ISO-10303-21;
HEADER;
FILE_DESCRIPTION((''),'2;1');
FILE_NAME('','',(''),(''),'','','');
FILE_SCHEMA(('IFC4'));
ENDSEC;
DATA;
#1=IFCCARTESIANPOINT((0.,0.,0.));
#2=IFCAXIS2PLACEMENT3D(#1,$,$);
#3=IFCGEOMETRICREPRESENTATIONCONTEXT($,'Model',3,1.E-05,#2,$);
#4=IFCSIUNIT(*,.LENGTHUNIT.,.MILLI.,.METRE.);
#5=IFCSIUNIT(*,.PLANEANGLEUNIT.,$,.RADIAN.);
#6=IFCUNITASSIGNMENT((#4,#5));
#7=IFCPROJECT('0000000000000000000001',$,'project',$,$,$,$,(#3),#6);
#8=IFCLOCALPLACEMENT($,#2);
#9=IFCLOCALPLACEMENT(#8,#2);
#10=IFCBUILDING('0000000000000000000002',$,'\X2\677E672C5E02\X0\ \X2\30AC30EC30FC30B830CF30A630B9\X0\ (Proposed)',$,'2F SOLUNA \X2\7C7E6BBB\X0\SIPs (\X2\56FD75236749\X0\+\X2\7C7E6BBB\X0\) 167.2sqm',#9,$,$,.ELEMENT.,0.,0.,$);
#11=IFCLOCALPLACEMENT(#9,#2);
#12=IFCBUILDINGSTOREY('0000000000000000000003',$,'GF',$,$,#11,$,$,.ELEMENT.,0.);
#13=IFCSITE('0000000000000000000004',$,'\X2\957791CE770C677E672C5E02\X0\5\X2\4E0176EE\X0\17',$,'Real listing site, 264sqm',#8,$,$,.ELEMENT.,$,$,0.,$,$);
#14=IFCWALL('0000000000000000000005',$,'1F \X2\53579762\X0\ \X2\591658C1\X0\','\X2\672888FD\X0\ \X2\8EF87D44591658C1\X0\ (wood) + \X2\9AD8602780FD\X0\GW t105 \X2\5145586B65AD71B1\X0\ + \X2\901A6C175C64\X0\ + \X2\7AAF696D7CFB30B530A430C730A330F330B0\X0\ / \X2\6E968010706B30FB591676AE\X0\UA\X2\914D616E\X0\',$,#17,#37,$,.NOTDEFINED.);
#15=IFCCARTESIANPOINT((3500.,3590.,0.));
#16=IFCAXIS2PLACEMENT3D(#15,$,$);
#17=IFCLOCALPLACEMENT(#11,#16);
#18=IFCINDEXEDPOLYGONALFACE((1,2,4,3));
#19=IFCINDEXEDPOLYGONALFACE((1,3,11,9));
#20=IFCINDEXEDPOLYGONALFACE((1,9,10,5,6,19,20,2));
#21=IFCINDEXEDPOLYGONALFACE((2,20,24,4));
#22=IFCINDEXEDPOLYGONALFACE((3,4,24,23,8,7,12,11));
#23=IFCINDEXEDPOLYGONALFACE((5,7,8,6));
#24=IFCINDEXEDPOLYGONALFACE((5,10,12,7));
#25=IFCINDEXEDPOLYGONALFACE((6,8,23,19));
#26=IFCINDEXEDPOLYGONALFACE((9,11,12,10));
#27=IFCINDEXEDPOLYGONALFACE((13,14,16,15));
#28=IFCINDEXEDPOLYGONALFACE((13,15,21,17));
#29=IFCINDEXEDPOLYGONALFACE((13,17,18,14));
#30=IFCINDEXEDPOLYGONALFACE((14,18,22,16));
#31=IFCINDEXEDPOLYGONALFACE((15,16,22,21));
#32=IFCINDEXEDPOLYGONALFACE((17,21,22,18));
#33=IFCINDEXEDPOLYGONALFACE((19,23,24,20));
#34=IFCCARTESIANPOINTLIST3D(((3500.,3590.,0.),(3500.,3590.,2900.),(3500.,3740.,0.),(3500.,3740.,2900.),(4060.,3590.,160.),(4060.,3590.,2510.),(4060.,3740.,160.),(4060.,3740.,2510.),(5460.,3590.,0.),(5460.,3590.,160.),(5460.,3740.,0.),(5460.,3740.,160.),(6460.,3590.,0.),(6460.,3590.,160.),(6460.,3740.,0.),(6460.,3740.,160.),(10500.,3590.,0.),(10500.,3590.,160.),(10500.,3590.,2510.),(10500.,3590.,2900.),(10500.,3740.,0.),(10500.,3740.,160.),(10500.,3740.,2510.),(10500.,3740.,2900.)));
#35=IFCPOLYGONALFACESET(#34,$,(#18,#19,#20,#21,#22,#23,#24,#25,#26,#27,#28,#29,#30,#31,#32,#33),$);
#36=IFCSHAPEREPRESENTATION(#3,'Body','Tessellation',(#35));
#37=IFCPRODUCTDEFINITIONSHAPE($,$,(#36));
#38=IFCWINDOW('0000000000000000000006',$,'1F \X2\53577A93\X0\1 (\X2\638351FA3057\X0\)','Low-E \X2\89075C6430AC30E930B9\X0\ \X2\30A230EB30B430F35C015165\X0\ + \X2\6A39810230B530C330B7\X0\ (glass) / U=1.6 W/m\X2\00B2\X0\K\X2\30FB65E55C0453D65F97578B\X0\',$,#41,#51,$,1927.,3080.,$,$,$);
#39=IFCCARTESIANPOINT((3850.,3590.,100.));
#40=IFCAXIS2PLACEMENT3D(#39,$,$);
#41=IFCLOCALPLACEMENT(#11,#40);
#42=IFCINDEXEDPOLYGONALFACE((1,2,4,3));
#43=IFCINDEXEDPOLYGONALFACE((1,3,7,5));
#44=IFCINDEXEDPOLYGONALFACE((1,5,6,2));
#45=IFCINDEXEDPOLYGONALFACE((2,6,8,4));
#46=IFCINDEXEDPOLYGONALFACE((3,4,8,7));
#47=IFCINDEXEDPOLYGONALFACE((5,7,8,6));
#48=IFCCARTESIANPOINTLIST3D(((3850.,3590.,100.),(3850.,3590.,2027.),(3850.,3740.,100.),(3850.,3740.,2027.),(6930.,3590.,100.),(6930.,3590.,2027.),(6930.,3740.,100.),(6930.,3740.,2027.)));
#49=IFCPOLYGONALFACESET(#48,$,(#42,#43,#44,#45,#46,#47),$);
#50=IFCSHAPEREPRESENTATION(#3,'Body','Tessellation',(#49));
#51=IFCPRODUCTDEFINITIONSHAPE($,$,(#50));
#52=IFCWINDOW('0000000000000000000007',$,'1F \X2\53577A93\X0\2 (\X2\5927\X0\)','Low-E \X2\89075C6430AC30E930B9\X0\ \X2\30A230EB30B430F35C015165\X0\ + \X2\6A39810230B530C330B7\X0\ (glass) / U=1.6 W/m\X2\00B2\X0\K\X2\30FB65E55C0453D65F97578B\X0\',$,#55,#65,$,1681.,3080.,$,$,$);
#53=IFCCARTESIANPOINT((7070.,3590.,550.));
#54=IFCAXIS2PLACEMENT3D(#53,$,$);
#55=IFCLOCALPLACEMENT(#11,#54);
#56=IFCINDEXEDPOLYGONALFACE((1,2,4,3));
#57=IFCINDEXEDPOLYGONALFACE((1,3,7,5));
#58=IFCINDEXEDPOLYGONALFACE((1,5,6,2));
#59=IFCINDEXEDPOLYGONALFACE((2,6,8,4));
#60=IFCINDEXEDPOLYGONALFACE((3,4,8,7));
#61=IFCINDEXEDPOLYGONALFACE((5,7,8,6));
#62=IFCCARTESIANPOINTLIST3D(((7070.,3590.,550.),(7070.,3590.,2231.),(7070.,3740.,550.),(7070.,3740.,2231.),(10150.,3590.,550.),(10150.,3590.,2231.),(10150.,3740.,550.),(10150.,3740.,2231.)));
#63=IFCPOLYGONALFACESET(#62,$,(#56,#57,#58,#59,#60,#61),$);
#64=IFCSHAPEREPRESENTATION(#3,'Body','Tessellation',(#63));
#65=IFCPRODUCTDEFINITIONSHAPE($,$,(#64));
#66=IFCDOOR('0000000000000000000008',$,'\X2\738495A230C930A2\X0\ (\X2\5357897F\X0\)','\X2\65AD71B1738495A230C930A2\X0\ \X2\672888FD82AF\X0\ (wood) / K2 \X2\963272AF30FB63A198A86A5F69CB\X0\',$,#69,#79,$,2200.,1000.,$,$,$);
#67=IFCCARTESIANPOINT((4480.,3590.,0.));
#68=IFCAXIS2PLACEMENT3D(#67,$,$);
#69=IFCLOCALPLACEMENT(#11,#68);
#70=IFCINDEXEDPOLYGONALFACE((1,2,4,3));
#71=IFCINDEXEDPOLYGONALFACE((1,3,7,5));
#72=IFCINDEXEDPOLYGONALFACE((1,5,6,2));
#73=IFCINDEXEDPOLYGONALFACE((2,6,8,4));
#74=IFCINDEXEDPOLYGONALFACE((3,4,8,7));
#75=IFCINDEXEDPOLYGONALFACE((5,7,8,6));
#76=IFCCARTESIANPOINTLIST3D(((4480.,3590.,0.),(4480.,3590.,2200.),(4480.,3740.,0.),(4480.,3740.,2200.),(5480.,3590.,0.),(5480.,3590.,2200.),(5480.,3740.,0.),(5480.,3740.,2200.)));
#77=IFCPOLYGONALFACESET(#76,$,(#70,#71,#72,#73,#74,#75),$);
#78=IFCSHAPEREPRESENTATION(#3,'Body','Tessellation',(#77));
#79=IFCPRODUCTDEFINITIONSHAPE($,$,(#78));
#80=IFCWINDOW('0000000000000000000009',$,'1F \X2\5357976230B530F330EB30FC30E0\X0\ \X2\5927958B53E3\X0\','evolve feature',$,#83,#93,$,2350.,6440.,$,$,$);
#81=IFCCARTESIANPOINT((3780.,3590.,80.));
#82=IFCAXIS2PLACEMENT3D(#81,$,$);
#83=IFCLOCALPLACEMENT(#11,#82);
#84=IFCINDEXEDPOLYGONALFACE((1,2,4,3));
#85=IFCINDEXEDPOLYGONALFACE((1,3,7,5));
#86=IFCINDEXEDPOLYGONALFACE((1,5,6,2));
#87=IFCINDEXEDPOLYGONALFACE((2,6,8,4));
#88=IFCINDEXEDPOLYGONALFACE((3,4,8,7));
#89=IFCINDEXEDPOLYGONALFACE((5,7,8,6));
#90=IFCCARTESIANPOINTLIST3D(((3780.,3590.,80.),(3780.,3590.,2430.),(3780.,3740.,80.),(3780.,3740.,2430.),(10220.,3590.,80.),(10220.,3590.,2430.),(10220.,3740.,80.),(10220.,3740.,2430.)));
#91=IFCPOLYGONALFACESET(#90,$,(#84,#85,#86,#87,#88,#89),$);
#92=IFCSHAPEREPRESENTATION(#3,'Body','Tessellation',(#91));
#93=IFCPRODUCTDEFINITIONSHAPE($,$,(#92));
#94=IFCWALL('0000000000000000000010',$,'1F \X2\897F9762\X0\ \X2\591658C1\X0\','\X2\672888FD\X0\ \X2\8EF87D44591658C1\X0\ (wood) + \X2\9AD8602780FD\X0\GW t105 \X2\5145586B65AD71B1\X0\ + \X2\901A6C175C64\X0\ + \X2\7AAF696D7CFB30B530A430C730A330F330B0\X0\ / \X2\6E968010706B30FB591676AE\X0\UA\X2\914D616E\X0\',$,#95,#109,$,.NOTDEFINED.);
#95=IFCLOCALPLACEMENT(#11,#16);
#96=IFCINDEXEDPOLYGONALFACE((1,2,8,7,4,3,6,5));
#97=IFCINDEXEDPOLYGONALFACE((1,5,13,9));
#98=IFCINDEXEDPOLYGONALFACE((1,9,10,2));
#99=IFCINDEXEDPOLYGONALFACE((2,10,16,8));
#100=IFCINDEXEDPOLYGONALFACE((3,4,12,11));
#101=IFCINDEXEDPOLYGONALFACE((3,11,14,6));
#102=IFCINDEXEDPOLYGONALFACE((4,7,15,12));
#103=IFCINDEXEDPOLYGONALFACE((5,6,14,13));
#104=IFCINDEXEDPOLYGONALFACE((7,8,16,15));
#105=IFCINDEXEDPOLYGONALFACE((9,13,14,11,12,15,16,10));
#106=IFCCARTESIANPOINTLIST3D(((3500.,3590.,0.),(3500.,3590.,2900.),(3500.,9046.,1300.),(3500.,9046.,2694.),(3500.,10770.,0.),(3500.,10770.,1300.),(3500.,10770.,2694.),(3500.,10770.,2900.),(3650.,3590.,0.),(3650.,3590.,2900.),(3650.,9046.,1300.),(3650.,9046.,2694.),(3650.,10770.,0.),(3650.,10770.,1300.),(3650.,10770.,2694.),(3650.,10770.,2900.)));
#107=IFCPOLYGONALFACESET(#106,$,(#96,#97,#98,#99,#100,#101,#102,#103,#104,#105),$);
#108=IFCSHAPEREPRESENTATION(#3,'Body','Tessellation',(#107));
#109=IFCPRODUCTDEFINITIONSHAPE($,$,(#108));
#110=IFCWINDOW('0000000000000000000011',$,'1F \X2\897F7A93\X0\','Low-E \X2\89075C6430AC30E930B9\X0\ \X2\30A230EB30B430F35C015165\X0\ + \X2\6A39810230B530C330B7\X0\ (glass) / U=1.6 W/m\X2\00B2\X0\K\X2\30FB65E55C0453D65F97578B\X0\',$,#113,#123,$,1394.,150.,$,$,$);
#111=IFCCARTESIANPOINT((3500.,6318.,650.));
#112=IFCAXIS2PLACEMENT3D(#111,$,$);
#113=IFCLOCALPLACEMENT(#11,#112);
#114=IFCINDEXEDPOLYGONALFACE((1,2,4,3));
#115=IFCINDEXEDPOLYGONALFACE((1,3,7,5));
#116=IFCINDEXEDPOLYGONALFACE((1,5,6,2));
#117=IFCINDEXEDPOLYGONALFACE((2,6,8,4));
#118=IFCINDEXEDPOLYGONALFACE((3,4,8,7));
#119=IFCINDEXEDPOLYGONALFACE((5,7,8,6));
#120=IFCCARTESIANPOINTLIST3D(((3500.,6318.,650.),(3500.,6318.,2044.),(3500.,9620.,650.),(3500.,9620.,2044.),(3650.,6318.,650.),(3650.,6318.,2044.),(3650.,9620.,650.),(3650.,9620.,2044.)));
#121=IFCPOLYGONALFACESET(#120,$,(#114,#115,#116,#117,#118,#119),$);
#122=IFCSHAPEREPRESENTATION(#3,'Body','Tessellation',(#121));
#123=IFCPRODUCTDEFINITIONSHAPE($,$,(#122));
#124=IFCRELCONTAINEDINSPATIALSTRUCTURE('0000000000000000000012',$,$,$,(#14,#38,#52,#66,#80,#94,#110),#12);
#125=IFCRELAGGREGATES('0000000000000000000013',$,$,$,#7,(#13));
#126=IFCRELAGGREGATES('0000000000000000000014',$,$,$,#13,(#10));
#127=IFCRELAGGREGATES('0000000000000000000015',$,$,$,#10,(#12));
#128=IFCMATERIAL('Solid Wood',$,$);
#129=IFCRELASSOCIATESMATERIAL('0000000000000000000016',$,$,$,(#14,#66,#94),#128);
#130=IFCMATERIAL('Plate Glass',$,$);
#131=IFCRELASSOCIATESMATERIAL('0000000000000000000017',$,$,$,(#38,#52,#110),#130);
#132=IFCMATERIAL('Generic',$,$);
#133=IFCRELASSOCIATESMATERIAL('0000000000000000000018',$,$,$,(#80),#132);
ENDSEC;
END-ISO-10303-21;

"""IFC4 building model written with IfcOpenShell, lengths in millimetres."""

from ifc_helpers import new_model, si_unit, frame, frame_2d, origin, place, context, project, spatial, rectangle, extrude, material, element, fill, save


model = new_model("IFC4")

# Units and contexts
model_context = context("Model", 3, precision=1e-05, world=origin())
ifc_project = project(units=[si_unit("LENGTHUNIT", "METRE", prefix="MILLI"), si_unit("PLANEANGLEUNIT", "RADIAN")], contexts=[model_context])

# Site, building, storey
site_placement = place(None, origin())
site = spatial("IfcSite", under=ifc_project, at=site_placement, Name="長野県松本市5丁目17", ObjectType="Real listing site, 264sqm", CompositionType="ELEMENT", RefElevation=0.0)
building_placement = place(site_placement, origin())
building = spatial("IfcBuilding", under=site, at=building_placement, Name="松本市 ガレージハウス (Proposed)", ObjectType="2F SOLUNA 籾殻SIPs (国産杉+籾殻) 167.2sqm", CompositionType="ELEMENT", ElevationOfRefHeight=0.0, ElevationOfTerrain=0.0)
storey_placement = place(building_placement, origin())
storey = spatial("IfcBuildingStorey", under=building, at=storey_placement, Name="GF", CompositionType="ELEMENT", Elevation=0.0)

# Shared definitions
ifc_material_1 = material(Name="Solid Wood")
ifc_material_2 = material(Name="Generic")

# Wall, openings, windows, door
wall_1_placement = place(storey_placement, frame((3500.0, 3590.0, 0.0)))
wall_1 = element("IfcWall", 1, at=wall_1_placement, inside=storey, material=ifc_material_1, Name="1F 南面 外壁", Description="木製 軸組外壁 (wood) + 高性能GW t105 充填断熱 + 通気層 + 窯業系サイディング / 準耐火・外皮UA配慮", PredefinedType="NOTDEFINED", context=model_context, shape_type="SweptSolid", body=[
    extrude(rectangle(XDim=7000.0, YDim=150.0, at=frame_2d((3500.0, 75.0))), frame((3500.0, 3590.0, 0.0)), (0.0, 0.0, 1.0), 2900.0),
])
opening_1_placement = place(storey_placement, frame((3850.0, 3590.0, 100.0)))
opening_1 = element("IfcOpeningElement", 2, at=opening_1_placement, cuts=wall_1, PredefinedType="NOTDEFINED", context=model_context, shape_type="SweptSolid", body=[
    extrude(rectangle(XDim=3080.0, YDim=150.0, at=frame_2d((1540.0, 75.0))), frame((3850.0, 3590.0, 100.0)), (0.0, 0.0, 1.0), 1927.0),
])
opening_2_placement = place(storey_placement, frame((7070.0, 3590.0, 550.0)))
opening_2 = element("IfcOpeningElement", 3, at=opening_2_placement, cuts=wall_1, PredefinedType="NOTDEFINED", context=model_context, shape_type="SweptSolid", body=[
    extrude(rectangle(XDim=3080.0, YDim=150.0, at=frame_2d((1540.0, 75.0))), frame((7070.0, 3590.0, 550.0)), (0.0, 0.0, 1.0), 1681.0),
])
opening_3_placement = place(storey_placement, frame((4480.0, 3590.0, 0.0)))
opening_3 = element("IfcOpeningElement", 4, at=opening_3_placement, cuts=wall_1, PredefinedType="NOTDEFINED", context=model_context, shape_type="SweptSolid", body=[
    extrude(rectangle(XDim=1000.0, YDim=150.0, at=frame_2d((500.0, 75.0))), frame((4480.0, 3590.0, 0.0)), (0.0, 0.0, 1.0), 2200.0),
])
opening_4_placement = place(storey_placement, frame((3780.0, 3590.0, 80.0)))
opening_4 = element("IfcOpeningElement", 5, at=opening_4_placement, cuts=wall_1, PredefinedType="NOTDEFINED", context=model_context, shape_type="SweptSolid", body=[
    extrude(rectangle(XDim=6440.0, YDim=150.0, at=frame_2d((3220.0, 75.0))), frame((3780.0, 3590.0, 80.0)), (0.0, 0.0, 1.0), 2350.0),
])
ifc_material_3 = material(Name="Plate Glass")
window_1_placement = place(storey_placement, frame((3850.0, 3590.0, 100.0)))
window_1 = element("IfcWindow", 6, at=window_1_placement, inside=storey, material=ifc_material_3, Name="1F 南窓1 (掃出し)", Description="Low-E 複層ガラス アルゴン封入 + 樹脂サッシ (glass) / U=1.6 W/m²K・日射取得型", OverallHeight=1927.0, OverallWidth=3080.0, context=model_context, shape_type="SweptSolid", body=[
    extrude(rectangle(XDim=3080.0, YDim=150.0, at=frame_2d((1540.0, 75.0))), frame((3850.0, 3590.0, 100.0)), (0.0, 0.0, 1.0), 1927.0),
])
fill(opening_1, window_1)
window_2_placement = place(storey_placement, frame((7070.0, 3590.0, 550.0)))
window_2 = element("IfcWindow", 7, at=window_2_placement, inside=storey, material=ifc_material_3, Name="1F 南窓2 (大)", Description="Low-E 複層ガラス アルゴン封入 + 樹脂サッシ (glass) / U=1.6 W/m²K・日射取得型", OverallHeight=1681.0, OverallWidth=3080.0, context=model_context, shape_type="SweptSolid", body=[
    extrude(rectangle(XDim=3080.0, YDim=150.0, at=frame_2d((1540.0, 75.0))), frame((7070.0, 3590.0, 550.0)), (0.0, 0.0, 1.0), 1681.0),
])
fill(opening_2, window_2)
door_placement = place(storey_placement, frame((4480.0, 3590.0, 0.0)))
door = element("IfcDoor", 8, at=door_placement, inside=storey, material=ifc_material_1, Name="玄関ドア (南西)", Description="断熱玄関ドア 木製芯 (wood) / K2 防犯・採風機構", OverallHeight=2200.0, OverallWidth=1000.0, context=model_context, shape_type="SweptSolid", body=[
    extrude(rectangle(XDim=1000.0, YDim=150.0, at=frame_2d((500.0, 75.0))), frame((4480.0, 3590.0, 0.0)), (0.0, 0.0, 1.0), 2200.0),
])
fill(opening_3, door)
window_3_placement = place(storey_placement, frame((3780.0, 3590.0, 80.0)))
window_3 = element("IfcWindow", 9, at=window_3_placement, inside=storey, material=ifc_material_2, Name="1F 南面サンルーム 大開口", Description="evolve feature", OverallHeight=2350.0, OverallWidth=6440.0, context=model_context, shape_type="SweptSolid", body=[
    extrude(rectangle(XDim=6440.0, YDim=150.0, at=frame_2d((3220.0, 75.0))), frame((3780.0, 3590.0, 80.0)), (0.0, 0.0, 1.0), 2350.0),
])
fill(opening_4, window_3)

# Wall, opening, window
wall_2_placement = place(storey_placement, frame((3500.0, 3590.0, 0.0)))
wall_2 = element("IfcWall", 10, at=wall_2_placement, inside=storey, material=ifc_material_1, Name="1F 西面 外壁", Description="木製 軸組外壁 (wood) + 高性能GW t105 充填断熱 + 通気層 + 窯業系サイディング / 準耐火・外皮UA配慮", PredefinedType="NOTDEFINED", context=model_context, shape_type="SweptSolid", body=[
    extrude(rectangle(XDim=150.0, YDim=7180.0, at=frame_2d((75.0, 3590.0))), frame((3500.0, 3590.0, 0.0)), (0.0, 0.0, 1.0), 2900.0),
])
opening_5_placement = place(storey_placement, frame((3500.0, 6318.0, 650.0)))
opening_5 = element("IfcOpeningElement", 11, at=opening_5_placement, cuts=wall_2, PredefinedType="NOTDEFINED", context=model_context, shape_type="SweptSolid", body=[
    extrude(rectangle(XDim=150.0, YDim=3302.0, at=frame_2d((75.0, 1651.0))), frame((3500.0, 6318.0, 650.0)), (0.0, 0.0, 1.0), 1394.0),
])
window_4_placement = place(storey_placement, frame((3500.0, 6318.0, 650.0)))
window_4 = element("IfcWindow", 12, at=window_4_placement, inside=storey, material=ifc_material_3, Name="1F 西窓", Description="Low-E 複層ガラス アルゴン封入 + 樹脂サッシ (glass) / U=1.6 W/m²K・日射取得型", OverallHeight=1394.0, OverallWidth=150.0, context=model_context, shape_type="SweptSolid", body=[
    extrude(rectangle(XDim=150.0, YDim=3302.0, at=frame_2d((75.0, 1651.0))), frame((3500.0, 6318.0, 650.0)), (0.0, 0.0, 1.0), 1394.0),
])
fill(opening_5, window_4)

save(model, "model.ifc")
